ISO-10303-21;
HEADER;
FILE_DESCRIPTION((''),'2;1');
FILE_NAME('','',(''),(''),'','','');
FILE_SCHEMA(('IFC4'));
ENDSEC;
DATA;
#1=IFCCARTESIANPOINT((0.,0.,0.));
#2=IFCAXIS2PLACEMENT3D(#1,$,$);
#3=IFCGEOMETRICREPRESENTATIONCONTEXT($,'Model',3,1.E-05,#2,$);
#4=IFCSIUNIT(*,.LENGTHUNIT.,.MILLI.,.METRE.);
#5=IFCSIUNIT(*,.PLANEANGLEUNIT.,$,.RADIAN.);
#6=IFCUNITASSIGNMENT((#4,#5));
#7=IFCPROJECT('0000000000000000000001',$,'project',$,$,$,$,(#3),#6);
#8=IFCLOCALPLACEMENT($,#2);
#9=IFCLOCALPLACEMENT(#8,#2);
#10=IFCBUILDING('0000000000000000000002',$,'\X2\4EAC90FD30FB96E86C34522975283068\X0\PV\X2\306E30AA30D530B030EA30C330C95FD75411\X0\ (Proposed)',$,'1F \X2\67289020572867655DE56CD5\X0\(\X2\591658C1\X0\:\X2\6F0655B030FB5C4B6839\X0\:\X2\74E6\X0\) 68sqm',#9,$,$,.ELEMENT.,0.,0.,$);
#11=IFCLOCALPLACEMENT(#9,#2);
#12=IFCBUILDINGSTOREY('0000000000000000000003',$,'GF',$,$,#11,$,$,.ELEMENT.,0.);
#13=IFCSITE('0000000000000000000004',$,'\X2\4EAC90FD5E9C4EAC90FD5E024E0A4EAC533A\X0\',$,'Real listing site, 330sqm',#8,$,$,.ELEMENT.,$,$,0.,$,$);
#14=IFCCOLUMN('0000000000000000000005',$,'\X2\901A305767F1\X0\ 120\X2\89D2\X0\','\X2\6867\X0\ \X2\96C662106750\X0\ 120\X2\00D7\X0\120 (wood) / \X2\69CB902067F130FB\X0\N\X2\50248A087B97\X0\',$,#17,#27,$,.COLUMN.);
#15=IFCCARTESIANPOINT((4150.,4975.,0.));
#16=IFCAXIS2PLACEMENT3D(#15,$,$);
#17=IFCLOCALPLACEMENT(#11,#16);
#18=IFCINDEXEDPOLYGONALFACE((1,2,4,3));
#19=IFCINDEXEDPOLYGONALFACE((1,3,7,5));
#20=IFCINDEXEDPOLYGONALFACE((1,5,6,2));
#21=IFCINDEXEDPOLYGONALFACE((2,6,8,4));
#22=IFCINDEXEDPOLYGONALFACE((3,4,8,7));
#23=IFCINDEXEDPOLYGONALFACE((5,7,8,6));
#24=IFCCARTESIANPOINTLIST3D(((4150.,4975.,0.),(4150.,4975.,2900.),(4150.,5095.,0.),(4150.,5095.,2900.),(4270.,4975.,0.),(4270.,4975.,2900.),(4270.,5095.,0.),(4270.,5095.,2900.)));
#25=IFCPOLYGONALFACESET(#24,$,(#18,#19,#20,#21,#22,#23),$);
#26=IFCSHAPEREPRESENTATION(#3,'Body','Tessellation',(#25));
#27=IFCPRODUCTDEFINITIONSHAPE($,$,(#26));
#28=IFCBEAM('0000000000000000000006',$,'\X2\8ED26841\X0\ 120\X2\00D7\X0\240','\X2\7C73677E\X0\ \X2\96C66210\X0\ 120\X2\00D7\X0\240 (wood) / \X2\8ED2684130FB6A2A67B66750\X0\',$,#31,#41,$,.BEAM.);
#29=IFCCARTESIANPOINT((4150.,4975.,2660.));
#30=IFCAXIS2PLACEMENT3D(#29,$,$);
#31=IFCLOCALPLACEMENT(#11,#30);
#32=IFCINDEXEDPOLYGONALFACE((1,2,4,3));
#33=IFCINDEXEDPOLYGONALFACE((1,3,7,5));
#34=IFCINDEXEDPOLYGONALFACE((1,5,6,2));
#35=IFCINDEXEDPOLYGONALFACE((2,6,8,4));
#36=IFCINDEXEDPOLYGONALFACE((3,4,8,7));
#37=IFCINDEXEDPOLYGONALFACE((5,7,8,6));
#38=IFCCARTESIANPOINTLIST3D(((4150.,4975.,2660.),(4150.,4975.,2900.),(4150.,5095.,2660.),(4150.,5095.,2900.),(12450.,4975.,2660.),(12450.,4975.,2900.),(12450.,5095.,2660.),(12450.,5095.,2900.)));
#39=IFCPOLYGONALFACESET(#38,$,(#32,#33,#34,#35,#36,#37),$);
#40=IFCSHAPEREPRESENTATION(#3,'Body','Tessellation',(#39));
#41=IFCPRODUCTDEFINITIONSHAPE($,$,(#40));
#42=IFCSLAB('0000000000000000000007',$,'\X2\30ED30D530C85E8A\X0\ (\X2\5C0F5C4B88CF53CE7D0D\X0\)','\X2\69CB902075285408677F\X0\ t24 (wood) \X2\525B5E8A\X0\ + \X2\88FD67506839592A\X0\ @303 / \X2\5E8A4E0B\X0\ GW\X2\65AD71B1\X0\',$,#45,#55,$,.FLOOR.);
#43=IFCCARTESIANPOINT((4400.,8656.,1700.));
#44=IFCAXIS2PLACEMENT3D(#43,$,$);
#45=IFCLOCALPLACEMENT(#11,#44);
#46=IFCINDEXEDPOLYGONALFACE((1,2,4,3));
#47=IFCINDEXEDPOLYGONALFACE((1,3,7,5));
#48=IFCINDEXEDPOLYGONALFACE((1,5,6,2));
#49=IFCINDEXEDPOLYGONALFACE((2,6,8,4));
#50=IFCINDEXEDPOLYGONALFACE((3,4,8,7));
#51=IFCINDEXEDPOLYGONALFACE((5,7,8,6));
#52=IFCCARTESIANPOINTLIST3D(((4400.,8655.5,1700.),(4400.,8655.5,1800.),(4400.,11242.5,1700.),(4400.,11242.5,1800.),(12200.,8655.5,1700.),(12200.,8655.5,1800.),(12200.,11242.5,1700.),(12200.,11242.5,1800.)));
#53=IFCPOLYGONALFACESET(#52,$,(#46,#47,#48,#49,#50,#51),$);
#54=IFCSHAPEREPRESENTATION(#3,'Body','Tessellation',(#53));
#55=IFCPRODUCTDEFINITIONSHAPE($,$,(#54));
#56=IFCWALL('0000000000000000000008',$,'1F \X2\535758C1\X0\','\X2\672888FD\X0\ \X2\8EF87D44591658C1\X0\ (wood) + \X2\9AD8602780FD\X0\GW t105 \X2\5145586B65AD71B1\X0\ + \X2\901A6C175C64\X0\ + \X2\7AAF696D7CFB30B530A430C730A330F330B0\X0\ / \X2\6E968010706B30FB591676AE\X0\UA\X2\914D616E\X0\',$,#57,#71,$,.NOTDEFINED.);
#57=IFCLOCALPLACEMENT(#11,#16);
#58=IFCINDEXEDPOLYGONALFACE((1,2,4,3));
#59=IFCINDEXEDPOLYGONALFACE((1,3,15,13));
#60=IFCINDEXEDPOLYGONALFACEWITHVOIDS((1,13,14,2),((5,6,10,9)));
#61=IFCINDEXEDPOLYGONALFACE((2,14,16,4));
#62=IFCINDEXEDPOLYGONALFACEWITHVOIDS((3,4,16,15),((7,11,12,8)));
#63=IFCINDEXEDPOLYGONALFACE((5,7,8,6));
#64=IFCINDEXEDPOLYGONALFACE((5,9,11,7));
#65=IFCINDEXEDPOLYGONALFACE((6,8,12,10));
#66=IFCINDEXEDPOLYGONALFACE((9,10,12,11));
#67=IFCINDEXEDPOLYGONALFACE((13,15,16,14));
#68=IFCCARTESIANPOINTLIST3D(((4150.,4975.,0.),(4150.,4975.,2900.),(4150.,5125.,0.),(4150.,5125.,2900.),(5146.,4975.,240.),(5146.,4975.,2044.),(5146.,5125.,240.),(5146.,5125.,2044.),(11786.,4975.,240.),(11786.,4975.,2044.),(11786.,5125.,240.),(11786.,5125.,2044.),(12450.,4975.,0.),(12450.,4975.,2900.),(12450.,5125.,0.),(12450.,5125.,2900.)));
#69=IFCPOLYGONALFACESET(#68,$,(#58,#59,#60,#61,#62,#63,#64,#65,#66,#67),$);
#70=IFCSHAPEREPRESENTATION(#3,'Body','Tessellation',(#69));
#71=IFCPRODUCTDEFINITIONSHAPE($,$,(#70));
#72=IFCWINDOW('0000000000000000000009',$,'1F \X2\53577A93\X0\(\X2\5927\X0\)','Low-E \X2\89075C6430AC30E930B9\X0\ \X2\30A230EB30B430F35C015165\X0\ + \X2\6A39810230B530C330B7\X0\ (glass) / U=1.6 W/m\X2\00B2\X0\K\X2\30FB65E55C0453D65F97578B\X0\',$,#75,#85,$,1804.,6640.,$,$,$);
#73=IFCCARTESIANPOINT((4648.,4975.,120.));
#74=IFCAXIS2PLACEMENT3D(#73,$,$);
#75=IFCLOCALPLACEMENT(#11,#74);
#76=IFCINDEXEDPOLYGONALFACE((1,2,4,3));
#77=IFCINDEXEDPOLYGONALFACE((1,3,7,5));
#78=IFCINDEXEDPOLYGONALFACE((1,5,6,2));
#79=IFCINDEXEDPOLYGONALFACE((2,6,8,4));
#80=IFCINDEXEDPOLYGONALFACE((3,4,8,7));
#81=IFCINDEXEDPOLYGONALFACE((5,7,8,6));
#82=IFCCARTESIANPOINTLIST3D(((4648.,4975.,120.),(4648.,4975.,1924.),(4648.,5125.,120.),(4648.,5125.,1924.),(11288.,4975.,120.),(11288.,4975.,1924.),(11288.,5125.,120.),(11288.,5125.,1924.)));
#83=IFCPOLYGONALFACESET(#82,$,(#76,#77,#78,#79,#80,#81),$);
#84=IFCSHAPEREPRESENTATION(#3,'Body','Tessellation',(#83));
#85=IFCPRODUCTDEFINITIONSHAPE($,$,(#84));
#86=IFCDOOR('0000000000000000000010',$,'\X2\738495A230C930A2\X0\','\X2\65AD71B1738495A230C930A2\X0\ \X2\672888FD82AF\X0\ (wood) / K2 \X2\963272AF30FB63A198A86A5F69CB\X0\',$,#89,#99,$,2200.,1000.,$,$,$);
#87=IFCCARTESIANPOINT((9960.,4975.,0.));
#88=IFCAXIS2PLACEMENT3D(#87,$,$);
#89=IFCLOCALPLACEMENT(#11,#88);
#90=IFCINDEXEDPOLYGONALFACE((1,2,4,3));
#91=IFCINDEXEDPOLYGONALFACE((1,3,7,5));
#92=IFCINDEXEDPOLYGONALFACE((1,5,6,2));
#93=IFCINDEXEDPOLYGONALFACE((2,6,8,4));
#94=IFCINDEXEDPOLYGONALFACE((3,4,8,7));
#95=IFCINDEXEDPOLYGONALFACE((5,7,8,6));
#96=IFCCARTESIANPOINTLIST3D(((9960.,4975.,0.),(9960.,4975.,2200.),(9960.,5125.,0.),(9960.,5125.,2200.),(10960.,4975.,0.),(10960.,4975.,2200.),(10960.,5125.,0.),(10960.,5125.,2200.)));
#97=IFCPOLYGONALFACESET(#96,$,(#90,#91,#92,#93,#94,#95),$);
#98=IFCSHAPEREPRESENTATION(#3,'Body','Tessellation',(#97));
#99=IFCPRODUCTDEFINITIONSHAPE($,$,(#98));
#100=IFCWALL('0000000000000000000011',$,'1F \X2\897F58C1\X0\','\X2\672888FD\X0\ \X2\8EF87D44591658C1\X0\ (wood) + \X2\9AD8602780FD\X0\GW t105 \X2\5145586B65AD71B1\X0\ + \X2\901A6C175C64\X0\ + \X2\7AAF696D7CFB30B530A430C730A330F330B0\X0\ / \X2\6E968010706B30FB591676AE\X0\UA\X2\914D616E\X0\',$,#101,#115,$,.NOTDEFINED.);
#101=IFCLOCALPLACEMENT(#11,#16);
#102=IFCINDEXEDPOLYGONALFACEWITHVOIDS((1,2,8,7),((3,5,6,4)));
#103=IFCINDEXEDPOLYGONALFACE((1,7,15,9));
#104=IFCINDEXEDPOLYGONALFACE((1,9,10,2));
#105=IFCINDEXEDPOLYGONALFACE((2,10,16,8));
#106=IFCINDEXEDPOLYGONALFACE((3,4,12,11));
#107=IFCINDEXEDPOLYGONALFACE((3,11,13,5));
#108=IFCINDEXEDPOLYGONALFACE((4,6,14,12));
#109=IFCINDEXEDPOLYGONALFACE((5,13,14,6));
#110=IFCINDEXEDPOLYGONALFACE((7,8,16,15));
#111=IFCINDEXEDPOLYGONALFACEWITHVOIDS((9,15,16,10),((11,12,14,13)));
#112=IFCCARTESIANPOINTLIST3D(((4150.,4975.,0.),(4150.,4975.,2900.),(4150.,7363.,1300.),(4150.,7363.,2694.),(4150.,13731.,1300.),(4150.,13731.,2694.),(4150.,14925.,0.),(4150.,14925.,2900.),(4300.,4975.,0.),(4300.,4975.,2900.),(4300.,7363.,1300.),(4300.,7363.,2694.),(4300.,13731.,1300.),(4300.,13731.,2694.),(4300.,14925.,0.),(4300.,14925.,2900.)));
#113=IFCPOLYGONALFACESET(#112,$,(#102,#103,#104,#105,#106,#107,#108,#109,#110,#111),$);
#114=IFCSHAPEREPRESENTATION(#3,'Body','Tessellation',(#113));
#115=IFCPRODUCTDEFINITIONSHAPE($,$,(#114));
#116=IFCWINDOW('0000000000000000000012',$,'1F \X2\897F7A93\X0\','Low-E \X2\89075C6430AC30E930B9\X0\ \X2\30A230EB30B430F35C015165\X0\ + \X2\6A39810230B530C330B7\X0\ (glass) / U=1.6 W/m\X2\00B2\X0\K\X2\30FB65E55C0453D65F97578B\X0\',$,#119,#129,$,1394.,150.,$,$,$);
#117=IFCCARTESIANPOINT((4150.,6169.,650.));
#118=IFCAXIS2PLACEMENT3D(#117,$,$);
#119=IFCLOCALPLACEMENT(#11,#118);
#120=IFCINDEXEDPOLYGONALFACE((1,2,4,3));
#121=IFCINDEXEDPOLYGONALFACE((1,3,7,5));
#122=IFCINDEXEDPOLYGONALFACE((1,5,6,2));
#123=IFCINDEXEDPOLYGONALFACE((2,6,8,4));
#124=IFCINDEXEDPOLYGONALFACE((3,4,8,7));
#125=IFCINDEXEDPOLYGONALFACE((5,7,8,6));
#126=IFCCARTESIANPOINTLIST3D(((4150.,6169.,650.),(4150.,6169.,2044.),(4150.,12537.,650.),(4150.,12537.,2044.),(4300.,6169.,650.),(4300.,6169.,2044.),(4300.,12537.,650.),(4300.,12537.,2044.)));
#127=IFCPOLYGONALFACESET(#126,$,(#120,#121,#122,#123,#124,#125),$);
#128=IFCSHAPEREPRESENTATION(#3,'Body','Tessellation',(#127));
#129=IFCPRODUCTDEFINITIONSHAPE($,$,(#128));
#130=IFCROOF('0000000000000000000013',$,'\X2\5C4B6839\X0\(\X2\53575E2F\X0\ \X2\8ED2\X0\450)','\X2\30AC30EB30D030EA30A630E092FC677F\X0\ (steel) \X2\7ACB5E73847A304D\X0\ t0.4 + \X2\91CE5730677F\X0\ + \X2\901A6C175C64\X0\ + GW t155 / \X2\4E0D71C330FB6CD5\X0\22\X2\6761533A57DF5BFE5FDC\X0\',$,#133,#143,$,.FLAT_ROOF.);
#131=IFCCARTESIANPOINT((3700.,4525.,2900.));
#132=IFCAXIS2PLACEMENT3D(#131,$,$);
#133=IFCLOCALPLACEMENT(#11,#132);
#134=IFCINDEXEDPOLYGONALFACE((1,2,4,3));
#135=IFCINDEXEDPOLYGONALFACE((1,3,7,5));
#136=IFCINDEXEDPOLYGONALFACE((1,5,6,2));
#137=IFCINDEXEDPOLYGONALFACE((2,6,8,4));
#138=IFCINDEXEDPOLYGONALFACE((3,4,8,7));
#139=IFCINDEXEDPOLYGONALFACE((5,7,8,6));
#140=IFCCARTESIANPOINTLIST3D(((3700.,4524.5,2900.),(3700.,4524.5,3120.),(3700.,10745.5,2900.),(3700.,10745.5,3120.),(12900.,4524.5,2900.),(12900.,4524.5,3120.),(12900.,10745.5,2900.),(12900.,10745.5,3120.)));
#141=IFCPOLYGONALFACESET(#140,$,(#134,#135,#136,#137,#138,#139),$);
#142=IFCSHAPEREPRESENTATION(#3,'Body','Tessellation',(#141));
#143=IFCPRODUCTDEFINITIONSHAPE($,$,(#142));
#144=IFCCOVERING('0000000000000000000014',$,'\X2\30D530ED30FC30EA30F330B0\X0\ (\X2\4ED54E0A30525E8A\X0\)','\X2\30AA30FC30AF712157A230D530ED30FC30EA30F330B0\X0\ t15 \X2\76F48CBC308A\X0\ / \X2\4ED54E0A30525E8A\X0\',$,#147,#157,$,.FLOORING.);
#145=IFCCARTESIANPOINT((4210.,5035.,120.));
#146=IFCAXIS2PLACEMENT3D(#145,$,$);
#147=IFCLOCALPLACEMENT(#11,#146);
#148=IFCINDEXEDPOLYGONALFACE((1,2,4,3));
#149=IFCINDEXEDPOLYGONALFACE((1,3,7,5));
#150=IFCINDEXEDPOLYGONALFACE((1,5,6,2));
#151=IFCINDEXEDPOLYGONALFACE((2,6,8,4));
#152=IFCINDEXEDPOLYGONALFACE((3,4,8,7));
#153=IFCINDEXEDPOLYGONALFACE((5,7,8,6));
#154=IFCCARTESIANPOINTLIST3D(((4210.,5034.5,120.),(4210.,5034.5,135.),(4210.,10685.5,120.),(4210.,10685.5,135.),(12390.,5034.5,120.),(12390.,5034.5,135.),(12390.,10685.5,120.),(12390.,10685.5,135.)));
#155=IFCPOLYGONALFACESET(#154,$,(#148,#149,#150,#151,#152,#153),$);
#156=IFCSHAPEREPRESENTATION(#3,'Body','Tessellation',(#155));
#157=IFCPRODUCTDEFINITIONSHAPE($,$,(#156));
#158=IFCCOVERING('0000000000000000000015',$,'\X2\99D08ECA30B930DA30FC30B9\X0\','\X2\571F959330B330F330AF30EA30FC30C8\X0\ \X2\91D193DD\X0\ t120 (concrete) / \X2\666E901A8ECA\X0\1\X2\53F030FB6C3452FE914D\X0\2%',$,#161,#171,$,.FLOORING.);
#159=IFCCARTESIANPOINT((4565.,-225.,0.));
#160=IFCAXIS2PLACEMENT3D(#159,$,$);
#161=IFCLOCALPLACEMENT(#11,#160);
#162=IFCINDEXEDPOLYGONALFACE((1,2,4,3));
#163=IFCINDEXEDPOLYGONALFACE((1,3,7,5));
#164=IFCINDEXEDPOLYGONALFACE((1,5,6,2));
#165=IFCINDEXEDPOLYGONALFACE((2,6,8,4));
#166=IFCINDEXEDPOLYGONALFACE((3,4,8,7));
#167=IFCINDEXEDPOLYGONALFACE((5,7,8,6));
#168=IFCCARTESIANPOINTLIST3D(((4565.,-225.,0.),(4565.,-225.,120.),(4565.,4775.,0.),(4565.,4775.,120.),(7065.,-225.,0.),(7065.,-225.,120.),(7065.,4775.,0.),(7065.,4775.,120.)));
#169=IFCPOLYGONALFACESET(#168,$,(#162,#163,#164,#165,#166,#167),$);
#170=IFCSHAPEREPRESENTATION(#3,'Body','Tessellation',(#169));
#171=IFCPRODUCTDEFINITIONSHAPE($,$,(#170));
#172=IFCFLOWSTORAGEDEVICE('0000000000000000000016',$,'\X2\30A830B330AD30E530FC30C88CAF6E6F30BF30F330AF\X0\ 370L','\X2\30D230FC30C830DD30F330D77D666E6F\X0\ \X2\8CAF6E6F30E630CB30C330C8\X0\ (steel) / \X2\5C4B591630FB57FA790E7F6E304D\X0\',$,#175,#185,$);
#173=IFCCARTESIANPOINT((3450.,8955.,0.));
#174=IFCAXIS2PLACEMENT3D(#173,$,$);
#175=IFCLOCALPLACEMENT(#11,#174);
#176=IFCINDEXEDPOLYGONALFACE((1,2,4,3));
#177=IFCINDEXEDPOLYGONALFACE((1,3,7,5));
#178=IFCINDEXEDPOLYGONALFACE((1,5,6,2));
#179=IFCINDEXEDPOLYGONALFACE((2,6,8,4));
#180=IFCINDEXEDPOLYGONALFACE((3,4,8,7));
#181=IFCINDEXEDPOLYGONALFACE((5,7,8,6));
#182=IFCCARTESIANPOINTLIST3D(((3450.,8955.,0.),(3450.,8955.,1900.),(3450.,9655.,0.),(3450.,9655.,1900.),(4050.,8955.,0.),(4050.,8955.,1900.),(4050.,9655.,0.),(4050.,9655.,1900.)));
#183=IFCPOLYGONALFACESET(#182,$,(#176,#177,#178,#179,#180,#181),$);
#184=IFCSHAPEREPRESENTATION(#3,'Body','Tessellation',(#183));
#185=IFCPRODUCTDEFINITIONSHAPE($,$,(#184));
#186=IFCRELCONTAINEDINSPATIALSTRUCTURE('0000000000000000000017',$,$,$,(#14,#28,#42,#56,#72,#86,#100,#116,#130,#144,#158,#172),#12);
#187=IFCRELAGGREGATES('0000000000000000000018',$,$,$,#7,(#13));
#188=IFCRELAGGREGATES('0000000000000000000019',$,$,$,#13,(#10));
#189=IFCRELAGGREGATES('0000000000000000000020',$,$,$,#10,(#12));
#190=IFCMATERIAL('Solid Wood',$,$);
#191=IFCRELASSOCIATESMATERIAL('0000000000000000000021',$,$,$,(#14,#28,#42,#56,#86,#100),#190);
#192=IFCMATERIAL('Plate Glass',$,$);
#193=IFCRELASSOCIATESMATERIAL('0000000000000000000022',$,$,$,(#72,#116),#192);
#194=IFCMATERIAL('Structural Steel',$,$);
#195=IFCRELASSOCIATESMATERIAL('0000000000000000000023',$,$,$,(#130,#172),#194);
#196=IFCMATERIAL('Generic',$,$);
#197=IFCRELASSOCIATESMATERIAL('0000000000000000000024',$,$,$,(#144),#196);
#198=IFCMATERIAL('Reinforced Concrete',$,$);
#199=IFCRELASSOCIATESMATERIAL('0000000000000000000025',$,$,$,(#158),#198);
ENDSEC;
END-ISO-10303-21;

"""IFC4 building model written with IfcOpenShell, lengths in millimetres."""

from ifc_helpers import new_model, si_unit, frame, frame_2d, origin, place, context, project, spatial, rectangle, extrude, material, element, fill, save


model = new_model("IFC4")

# Units and contexts
model_context = context("Model", 3, precision=1e-05, world=origin())
ifc_project = project(units=[si_unit("LENGTHUNIT", "METRE", prefix="MILLI"), si_unit("PLANEANGLEUNIT", "RADIAN")], contexts=[model_context])

# Site, building, storey
site_placement = place(None, origin())
site = spatial("IfcSite", under=ifc_project, at=site_placement, Name="京都府京都市上京区", ObjectType="Real listing site, 330sqm", CompositionType="ELEMENT", RefElevation=0.0)
building_placement = place(site_placement, origin())
building = spatial("IfcBuilding", under=site, at=building_placement, Name="京都・雨水利用とPVのオフグリッド志向 (Proposed)", ObjectType="1F 木造在来工法(外壁:漆喰・屋根:瓦) 68sqm", CompositionType="ELEMENT", ElevationOfRefHeight=0.0, ElevationOfTerrain=0.0)
storey_placement = place(building_placement, origin())
storey = spatial("IfcBuildingStorey", under=building, at=storey_placement, Name="GF", CompositionType="ELEMENT", Elevation=0.0)

# Column
ifc_material_1 = material(Name="Solid Wood")
column_1_placement = place(storey_placement, frame((4150.0, 4975.0, 0.0)))
element("IfcColumn", 1, at=column_1_placement, inside=storey, material=ifc_material_1, Name="通し柱 120角", Description="桧 集成材 120×120 (wood) / 構造柱・N値計算", PredefinedType="COLUMN", context=model_context, shape_type="SweptSolid", body=[
    extrude(rectangle(XDim=120.0, YDim=120.0, at=frame_2d((60.0, 60.0))), frame((4150.0, 4975.0, 0.0)), (0.0, 0.0, 1.0), 2900.0),
])

# Beam
beam_1_placement = place(storey_placement, frame((4150.0, 4975.0, 2660.0)))
element("IfcBeam", 2, at=beam_1_placement, inside=storey, material=ifc_material_1, Name="軒桁 120×240", Description="米松 集成 120×240 (wood) / 軒桁・横架材", PredefinedType="BEAM", context=model_context, shape_type="SweptSolid", body=[
    extrude(rectangle(XDim=8300.0, YDim=120.0, at=frame_2d((4150.0, 60.0))), frame((4150.0, 4975.0, 2660.0)), (0.0, 0.0, 1.0), 240.0),
])

# Slab
ifc_material_2 = material(Name="Reinforced Concrete")
slab_1_placement = place(storey_placement, frame((4400.0, 8656.0, 1700.0)))
element("IfcSlab", 3, at=slab_1_placement, inside=storey, material=ifc_material_1, Name="ロフト床 (小屋裏収納)", Description="構造用合板 t24 (wood) 剛床 + 製材根太 @303 / 床下 GW断熱", PredefinedType="FLOOR", context=model_context, shape_type="SweptSolid", body=[
    extrude(rectangle(XDim=7800.0, YDim=2587.0, at=frame_2d((3900.0, 1293.0))), frame((4400.0, 8656.0, 1700.0)), (0.0, 0.0, 1.0), 100.0),
])

# Wall, openings, window, door
wall_1_placement = place(storey_placement, frame((4150.0, 4975.0, 0.0)))
wall_1 = element("IfcWall", 4, at=wall_1_placement, inside=storey, material=ifc_material_1, Name="1F 南壁", Description="木製 軸組外壁 (wood) + 高性能GW t105 充填断熱 + 通気層 + 窯業系サイディング / 準耐火・外皮UA配慮", PredefinedType="NOTDEFINED", context=model_context, shape_type="SweptSolid", body=[
    extrude(rectangle(XDim=8300.0, YDim=150.0, at=frame_2d((4150.0, 75.0))), frame((4150.0, 4975.0, 0.0)), (0.0, 0.0, 1.0), 2900.0),
])
opening_1_placement = place(storey_placement, frame((4648.0, 4975.0, 120.0)))
opening_1 = element("IfcOpeningElement", 5, at=opening_1_placement, cuts=wall_1, PredefinedType="NOTDEFINED", context=model_context, shape_type="SweptSolid", body=[
    extrude(rectangle(XDim=6640.0, YDim=150.0, at=frame_2d((3320.0, 75.0))), frame((4648.0, 4975.0, 120.0)), (0.0, 0.0, 1.0), 1804.0),
])
opening_2_placement = place(storey_placement, frame((9960.0, 4975.0, 0.0)))
opening_2 = element("IfcOpeningElement", 6, at=opening_2_placement, cuts=wall_1, PredefinedType="NOTDEFINED", context=model_context, shape_type="SweptSolid", body=[
    extrude(rectangle(XDim=1000.0, YDim=150.0, at=frame_2d((500.0, 75.0))), frame((9960.0, 4975.0, 0.0)), (0.0, 0.0, 1.0), 2200.0),
])
ifc_material_3 = material(Name="Plate Glass")
window_1_placement = place(storey_placement, frame((4648.0, 4975.0, 120.0)))
window_1 = element("IfcWindow", 7, at=window_1_placement, inside=storey, material=ifc_material_3, Name="1F 南窓(大)", Description="Low-E 複層ガラス アルゴン封入 + 樹脂サッシ (glass) / U=1.6 W/m²K・日射取得型", OverallHeight=1804.0, OverallWidth=6640.0, context=model_context, shape_type="SweptSolid", body=[
    extrude(rectangle(XDim=6640.0, YDim=150.0, at=frame_2d((3320.0, 75.0))), frame((4648.0, 4975.0, 120.0)), (0.0, 0.0, 1.0), 1804.0),
])
fill(opening_1, window_1)
door_placement = place(storey_placement, frame((9960.0, 4975.0, 0.0)))
door = element("IfcDoor", 8, at=door_placement, inside=storey, material=ifc_material_1, Name="玄関ドア", Description="断熱玄関ドア 木製芯 (wood) / K2 防犯・採風機構", OverallHeight=2200.0, OverallWidth=1000.0, context=model_context, shape_type="SweptSolid", body=[
    extrude(rectangle(XDim=1000.0, YDim=150.0, at=frame_2d((500.0, 75.0))), frame((9960.0, 4975.0, 0.0)), (0.0, 0.0, 1.0), 2200.0),
])
fill(opening_2, door)

# Wall, opening, window
wall_2_placement = place(storey_placement, frame((4150.0, 4975.0, 0.0)))
wall_2 = element("IfcWall", 9, at=wall_2_placement, inside=storey, material=ifc_material_1, Name="1F 西壁", Description="木製 軸組外壁 (wood) + 高性能GW t105 充填断熱 + 通気層 + 窯業系サイディング / 準耐火・外皮UA配慮", PredefinedType="NOTDEFINED", context=model_context, shape_type="SweptSolid", body=[
    extrude(rectangle(XDim=150.0, YDim=9950.0, at=frame_2d((75.0, 4975.0))), frame((4150.0, 4975.0, 0.0)), (0.0, 0.0, 1.0), 2900.0),
])
opening_3_placement = place(storey_placement, frame((4150.0, 6169.0, 650.0)))
opening_3 = element("IfcOpeningElement", 10, at=opening_3_placement, cuts=wall_2, PredefinedType="NOTDEFINED", context=model_context, shape_type="SweptSolid", body=[
    extrude(rectangle(XDim=150.0, YDim=6368.0, at=frame_2d((75.0, 3184.0))), frame((4150.0, 6169.0, 650.0)), (0.0, 0.0, 1.0), 1394.0),
])
window_2_placement = place(storey_placement, frame((4150.0, 6169.0, 650.0)))
window_2 = element("IfcWindow", 11, at=window_2_placement, inside=storey, material=ifc_material_3, Name="1F 西窓", Description="Low-E 複層ガラス アルゴン封入 + 樹脂サッシ (glass) / U=1.6 W/m²K・日射取得型", OverallHeight=1394.0, OverallWidth=150.0, context=model_context, shape_type="SweptSolid", body=[
    extrude(rectangle(XDim=150.0, YDim=6368.0, at=frame_2d((75.0, 3184.0))), frame((4150.0, 6169.0, 650.0)), (0.0, 0.0, 1.0), 1394.0),
])
fill(opening_3, window_2)

# Roof
ifc_material_4 = material(Name="Structural Steel")
roof_placement = place(storey_placement, frame((3700.0, 4525.0, 2900.0)))
element("IfcRoof", 12, at=roof_placement, inside=storey, material=ifc_material_4, Name="屋根(南帯 軒450)", Description="ガルバリウム鋼板 (steel) 立平葺き t0.4 + 野地板 + 通気層 + GW t155 / 不燃・法22条区域対応", PredefinedType="FLAT_ROOF", context=model_context, shape_type="SweptSolid", body=[
    extrude(rectangle(XDim=9200.0, YDim=6221.0, at=frame_2d((4600.0, 3110.0))), frame((3700.0, 4525.0, 2900.0)), (0.0, 0.0, 1.0), 220.0),
])

# Coverings
ifc_material_5 = material(Name="Generic")
covering_1_placement = place(storey_placement, frame((4210.0, 5035.0, 120.0)))
element("IfcCovering", 13, at=covering_1_placement, inside=storey, material=ifc_material_5, Name="フローリング (仕上げ床)", Description="オーク無垢フローリング t15 直貼り / 仕上げ床", PredefinedType="FLOORING", context=model_context, shape_type="SweptSolid", body=[
    extrude(rectangle(XDim=8180.0, YDim=5651.0, at=frame_2d((4090.0, 2825.0))), frame((4210.0, 5035.0, 120.0)), (0.0, 0.0, 1.0), 15.0),
])
covering_2_placement = place(storey_placement, frame((4565.0, -225.0, 0.0)))
element("IfcCovering", 14, at=covering_2_placement, inside=storey, material=ifc_material_2, Name="駐車スペース", Description="土間コンクリート 金鏝 t120 (concrete) / 普通車1台・水勾配2%", PredefinedType="FLOORING", context=model_context, shape_type="SweptSolid", body=[
    extrude(rectangle(XDim=2500.0, YDim=5000.0, at=frame_2d((1250.0, 2500.0))), frame((4565.0, -225.0, 0.0)), (0.0, 0.0, 1.0), 120.0),
])

# Flow storage device
flow_storage_device_1_placement = place(storey_placement, frame((3450.0, 8955.0, 0.0)))
element("IfcFlowStorageDevice", 15, at=flow_storage_device_1_placement, inside=storey, material=ifc_material_4, Name="エコキュート貯湯タンク 370L", Description="ヒートポンプ給湯 貯湯ユニット (steel) / 屋外・基礎置き", context=model_context, shape_type="SweptSolid", body=[
    extrude(rectangle(XDim=600.0, YDim=700.0, at=frame_2d((300.0, 350.0))), frame((3450.0, 8955.0, 0.0)), (0.0, 0.0, 1.0), 1900.0),
])

save(model, "model.ifc")
